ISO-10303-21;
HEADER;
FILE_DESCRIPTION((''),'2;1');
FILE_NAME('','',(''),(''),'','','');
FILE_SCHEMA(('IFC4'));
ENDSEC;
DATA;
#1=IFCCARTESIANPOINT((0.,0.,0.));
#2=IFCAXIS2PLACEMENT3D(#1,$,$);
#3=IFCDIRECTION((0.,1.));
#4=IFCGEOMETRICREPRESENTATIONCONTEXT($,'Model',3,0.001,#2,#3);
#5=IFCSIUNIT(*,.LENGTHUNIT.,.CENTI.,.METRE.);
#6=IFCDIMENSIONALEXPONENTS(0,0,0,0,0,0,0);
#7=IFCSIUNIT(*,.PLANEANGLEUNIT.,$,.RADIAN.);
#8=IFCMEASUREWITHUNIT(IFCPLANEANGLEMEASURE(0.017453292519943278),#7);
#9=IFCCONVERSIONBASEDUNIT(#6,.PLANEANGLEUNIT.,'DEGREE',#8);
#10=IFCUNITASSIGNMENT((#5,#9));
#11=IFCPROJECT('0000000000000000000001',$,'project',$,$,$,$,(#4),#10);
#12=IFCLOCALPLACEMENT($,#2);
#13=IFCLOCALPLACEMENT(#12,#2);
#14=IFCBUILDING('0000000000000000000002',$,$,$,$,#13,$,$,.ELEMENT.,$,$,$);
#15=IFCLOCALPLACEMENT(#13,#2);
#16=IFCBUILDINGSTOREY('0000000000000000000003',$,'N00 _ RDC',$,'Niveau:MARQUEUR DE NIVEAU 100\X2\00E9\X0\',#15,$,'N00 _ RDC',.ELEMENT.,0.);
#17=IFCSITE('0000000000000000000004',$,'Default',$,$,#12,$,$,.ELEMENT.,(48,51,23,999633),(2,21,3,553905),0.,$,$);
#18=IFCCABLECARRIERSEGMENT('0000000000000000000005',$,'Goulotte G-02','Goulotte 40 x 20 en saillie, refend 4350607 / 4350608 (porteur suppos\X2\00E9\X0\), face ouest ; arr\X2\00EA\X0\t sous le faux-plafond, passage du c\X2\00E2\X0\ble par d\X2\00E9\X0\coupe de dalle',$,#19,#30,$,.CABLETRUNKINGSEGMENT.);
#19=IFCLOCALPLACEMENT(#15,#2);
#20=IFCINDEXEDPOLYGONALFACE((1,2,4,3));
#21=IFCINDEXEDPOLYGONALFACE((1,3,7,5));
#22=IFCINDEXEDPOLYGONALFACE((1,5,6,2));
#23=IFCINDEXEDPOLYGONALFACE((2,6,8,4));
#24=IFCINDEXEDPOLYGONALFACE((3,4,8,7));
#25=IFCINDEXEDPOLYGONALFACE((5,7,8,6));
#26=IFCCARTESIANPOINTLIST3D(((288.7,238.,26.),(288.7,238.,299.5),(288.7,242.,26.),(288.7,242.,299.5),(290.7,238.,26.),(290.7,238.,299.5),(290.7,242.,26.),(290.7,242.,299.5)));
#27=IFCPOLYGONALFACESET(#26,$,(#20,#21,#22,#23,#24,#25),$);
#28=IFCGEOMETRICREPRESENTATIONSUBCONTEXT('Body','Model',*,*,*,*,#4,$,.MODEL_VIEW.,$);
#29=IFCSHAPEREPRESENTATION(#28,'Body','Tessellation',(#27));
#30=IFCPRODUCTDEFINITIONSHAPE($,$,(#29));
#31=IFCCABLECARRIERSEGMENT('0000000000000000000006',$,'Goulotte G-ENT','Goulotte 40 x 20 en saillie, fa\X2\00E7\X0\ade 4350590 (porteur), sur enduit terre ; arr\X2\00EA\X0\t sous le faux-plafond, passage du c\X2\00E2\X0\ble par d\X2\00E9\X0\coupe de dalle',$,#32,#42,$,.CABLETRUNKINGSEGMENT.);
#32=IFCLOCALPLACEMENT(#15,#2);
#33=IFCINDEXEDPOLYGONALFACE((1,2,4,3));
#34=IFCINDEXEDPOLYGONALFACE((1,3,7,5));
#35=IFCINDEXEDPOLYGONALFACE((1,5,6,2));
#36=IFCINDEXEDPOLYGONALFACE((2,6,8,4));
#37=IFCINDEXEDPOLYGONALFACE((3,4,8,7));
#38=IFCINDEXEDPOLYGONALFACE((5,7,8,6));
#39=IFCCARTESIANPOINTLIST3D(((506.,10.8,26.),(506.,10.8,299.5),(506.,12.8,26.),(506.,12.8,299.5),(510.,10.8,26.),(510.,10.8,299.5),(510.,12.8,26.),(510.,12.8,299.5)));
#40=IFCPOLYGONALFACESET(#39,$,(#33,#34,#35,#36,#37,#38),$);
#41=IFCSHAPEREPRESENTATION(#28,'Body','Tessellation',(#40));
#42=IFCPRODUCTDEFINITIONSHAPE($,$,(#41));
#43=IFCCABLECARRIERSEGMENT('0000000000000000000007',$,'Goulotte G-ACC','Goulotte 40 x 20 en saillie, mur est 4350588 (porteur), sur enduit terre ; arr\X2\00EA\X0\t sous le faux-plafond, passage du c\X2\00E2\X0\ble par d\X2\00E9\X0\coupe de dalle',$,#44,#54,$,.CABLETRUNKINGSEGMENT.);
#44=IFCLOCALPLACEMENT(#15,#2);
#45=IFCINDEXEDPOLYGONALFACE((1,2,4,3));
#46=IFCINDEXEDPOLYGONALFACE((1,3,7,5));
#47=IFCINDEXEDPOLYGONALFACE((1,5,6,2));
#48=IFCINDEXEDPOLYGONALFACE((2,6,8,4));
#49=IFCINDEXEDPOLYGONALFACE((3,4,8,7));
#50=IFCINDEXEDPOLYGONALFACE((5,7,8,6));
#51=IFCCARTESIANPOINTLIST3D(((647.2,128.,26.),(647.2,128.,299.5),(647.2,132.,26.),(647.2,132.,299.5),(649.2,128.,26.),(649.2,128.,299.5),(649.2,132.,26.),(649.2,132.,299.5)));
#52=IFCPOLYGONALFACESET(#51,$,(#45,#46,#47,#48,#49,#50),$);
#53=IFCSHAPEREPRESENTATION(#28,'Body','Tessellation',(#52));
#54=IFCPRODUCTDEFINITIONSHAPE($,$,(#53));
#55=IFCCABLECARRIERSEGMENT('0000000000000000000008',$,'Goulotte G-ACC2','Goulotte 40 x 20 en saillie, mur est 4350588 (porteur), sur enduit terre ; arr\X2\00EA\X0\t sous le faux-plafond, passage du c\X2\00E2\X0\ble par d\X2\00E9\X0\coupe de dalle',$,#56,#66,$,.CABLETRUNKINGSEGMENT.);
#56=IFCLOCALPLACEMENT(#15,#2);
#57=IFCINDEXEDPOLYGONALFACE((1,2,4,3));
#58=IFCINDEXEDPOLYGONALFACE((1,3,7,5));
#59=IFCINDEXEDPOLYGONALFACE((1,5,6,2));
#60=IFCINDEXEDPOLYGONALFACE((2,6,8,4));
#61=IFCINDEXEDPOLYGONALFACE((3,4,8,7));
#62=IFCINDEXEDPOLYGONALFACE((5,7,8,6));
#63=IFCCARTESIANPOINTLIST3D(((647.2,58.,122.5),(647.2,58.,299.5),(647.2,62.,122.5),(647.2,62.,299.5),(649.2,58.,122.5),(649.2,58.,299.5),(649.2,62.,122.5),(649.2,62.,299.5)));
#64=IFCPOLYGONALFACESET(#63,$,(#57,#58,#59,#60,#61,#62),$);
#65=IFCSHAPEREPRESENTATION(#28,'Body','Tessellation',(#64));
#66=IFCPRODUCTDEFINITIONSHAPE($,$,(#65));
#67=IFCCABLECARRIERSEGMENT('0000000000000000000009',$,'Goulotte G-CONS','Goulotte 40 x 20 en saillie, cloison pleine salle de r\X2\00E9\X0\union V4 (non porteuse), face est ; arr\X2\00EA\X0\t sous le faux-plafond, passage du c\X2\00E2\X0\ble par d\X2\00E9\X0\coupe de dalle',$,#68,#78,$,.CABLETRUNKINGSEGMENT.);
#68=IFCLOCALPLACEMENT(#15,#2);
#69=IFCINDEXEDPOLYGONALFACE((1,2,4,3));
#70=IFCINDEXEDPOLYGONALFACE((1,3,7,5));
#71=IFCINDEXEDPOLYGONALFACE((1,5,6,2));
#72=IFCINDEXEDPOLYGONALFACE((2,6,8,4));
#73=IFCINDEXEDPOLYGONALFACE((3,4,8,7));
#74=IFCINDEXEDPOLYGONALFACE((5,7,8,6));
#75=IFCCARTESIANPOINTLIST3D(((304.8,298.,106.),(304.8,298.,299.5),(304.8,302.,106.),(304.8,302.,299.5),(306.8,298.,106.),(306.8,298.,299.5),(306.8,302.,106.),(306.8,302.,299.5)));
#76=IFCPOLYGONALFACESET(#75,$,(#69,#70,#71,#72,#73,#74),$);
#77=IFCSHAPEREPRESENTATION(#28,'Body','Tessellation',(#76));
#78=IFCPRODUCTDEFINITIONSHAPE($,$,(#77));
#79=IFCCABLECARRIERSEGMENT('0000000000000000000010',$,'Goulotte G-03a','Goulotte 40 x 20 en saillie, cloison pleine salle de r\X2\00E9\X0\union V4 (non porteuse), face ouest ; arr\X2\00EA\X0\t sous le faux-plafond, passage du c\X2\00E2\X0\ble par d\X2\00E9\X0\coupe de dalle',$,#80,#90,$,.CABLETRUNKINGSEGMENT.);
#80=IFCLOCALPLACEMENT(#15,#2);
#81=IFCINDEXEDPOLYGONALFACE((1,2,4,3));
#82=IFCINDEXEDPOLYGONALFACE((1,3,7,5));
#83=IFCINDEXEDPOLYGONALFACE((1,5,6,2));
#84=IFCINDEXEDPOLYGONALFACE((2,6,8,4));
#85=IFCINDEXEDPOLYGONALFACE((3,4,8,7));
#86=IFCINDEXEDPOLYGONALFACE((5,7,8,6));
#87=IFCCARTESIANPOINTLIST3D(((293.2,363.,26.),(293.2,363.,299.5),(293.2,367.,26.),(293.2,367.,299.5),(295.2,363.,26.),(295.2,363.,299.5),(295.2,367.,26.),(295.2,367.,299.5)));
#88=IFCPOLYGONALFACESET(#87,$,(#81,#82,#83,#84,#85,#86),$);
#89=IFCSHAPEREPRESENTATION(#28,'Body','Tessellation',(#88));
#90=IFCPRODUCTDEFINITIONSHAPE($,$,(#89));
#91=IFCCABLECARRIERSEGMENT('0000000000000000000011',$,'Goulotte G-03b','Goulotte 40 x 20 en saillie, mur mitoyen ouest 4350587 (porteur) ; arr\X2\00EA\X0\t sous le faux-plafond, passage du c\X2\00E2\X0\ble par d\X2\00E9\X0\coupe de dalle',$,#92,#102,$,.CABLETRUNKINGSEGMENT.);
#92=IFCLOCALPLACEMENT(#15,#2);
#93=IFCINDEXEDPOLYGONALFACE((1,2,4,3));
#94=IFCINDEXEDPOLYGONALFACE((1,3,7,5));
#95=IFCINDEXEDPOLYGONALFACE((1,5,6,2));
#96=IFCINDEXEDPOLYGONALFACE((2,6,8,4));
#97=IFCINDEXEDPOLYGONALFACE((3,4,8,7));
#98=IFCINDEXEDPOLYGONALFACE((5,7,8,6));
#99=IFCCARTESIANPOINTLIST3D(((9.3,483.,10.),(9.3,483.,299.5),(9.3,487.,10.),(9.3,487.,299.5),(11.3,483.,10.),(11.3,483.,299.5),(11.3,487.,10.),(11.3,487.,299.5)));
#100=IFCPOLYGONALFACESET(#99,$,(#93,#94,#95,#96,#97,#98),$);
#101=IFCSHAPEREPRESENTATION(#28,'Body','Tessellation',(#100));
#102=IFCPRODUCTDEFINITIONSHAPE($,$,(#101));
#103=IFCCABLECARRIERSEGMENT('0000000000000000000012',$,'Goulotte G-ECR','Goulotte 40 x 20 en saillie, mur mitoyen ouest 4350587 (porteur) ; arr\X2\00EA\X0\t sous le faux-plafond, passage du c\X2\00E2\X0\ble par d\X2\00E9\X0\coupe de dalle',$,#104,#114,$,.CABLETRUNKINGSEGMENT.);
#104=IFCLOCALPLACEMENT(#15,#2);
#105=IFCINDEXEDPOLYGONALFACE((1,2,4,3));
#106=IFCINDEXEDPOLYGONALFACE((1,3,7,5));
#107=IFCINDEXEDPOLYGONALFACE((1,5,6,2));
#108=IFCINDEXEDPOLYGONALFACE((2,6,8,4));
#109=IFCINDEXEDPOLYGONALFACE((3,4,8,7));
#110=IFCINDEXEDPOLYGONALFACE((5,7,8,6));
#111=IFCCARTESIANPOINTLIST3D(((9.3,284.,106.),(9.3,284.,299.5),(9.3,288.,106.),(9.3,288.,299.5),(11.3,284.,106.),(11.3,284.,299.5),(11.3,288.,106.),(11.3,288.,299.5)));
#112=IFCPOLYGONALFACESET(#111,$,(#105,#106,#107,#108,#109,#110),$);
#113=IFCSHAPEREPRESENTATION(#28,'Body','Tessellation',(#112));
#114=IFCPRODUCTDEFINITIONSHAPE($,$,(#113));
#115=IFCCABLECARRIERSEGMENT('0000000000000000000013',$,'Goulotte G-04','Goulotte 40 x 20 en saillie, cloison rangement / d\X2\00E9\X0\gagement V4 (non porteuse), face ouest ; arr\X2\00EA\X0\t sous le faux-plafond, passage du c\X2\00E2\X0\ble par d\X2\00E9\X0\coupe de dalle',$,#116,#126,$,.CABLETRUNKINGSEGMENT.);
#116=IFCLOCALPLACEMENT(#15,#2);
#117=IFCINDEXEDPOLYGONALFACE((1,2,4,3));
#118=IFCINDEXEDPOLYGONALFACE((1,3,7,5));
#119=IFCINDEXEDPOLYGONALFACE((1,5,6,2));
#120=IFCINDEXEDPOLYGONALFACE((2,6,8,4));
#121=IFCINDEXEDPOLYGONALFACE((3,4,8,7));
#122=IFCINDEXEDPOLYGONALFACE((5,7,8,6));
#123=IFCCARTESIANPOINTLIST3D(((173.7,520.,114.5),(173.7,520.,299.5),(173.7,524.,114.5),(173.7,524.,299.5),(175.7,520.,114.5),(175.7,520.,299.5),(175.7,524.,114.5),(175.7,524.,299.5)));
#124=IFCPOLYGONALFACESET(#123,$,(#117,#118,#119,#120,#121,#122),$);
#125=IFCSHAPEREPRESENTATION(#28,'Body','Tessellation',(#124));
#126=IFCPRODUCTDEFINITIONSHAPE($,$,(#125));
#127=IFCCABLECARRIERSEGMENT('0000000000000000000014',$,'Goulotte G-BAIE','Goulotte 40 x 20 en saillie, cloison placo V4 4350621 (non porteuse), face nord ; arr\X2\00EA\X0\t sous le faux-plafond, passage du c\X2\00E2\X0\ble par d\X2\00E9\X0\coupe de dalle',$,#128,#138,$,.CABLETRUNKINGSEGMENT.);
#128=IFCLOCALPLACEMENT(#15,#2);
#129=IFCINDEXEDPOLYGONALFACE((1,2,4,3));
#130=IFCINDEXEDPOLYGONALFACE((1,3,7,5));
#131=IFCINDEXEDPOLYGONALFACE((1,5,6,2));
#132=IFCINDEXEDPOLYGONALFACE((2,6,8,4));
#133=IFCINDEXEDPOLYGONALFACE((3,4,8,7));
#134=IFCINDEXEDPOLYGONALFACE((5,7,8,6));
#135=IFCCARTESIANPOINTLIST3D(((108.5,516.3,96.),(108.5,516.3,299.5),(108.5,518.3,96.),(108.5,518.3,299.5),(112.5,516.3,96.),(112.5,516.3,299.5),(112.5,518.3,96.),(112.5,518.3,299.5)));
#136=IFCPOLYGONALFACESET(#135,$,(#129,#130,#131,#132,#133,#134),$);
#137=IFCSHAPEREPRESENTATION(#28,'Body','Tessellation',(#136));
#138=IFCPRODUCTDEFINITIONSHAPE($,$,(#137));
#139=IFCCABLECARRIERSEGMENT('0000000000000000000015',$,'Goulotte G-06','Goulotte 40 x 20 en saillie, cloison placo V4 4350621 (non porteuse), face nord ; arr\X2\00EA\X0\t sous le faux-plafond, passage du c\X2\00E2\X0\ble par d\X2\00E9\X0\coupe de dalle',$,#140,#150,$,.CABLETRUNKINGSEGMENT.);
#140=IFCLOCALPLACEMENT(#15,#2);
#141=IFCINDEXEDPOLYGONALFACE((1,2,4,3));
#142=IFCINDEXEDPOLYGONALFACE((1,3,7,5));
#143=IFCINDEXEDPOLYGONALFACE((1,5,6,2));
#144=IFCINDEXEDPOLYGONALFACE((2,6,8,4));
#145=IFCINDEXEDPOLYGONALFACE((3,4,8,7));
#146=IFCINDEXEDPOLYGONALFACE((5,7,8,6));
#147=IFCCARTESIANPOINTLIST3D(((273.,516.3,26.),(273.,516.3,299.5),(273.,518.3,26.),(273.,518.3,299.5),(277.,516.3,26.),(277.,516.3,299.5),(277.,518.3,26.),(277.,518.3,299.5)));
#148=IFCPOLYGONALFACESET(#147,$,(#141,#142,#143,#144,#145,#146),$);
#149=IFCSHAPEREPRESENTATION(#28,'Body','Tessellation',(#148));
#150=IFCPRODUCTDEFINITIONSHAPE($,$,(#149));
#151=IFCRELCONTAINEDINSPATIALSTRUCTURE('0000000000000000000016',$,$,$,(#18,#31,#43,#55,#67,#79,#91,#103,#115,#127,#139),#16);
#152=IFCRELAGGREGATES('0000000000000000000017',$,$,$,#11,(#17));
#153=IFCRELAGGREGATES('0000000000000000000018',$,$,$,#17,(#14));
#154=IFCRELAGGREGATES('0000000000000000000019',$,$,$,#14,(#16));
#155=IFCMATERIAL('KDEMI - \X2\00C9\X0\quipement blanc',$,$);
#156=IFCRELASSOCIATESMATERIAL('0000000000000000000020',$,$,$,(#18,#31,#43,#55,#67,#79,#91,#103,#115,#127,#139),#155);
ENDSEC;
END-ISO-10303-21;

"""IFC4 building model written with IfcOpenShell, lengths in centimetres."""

from ifc_helpers import new_model, entity, si_unit, converted_unit, direction, frame, frame_2d, origin, origin_with_axes, place, context, subcontext, project, spatial, rectangle, extrude, material, element, save


model = new_model("IFC4")

# Units and contexts
model_context = context("Model", 3, precision=0.001, world=origin(), true_north=direction((0.0, 1.0)))
body_context = subcontext(model_context, "Body", "Model", "MODEL_VIEW")
ifc_project = project(units=[si_unit("LENGTHUNIT", "METRE", prefix="CENTI"), converted_unit("PLANEANGLEUNIT", "DEGREE", entity("IfcPlaneAngleMeasure", 0.017453292519943278), si_unit("PLANEANGLEUNIT", "RADIAN"), dimensions=[0, 0, 0, 0, 0, 0, 0])], contexts=[model_context])

# Site, building, storey
site_placement = place(None, origin())
site = spatial("IfcSite", under=ifc_project, at=site_placement, Name="Default", CompositionType="ELEMENT", RefLatitude=(48, 51, 23, 999633), RefLongitude=(2, 21, 3, 553905), RefElevation=0.0)
building_placement = place(site_placement, origin())
building = spatial("IfcBuilding", under=site, at=building_placement, CompositionType="ELEMENT")
storey_placement = place(building_placement, origin())
storey = spatial("IfcBuildingStorey", under=building, at=storey_placement, Name="N00 _ RDC", ObjectType="Niveau:MARQUEUR DE NIVEAU 100é", LongName="N00 _ RDC", CompositionType="ELEMENT", Elevation=0.0)

# Shared definitions
ifc_material_1 = material(Name="KDEMI - Équipement blanc")

# Cable carrier segments
cable_carrier_segment_1_placement = place(storey_placement, origin_with_axes())
element("IfcCableCarrierSegment", 1, at=cable_carrier_segment_1_placement, inside=storey, material=ifc_material_1, Name="Goulotte G-02", Description="Goulotte 40 x 20 en saillie, refend 4350607 / 4350608 (porteur supposé), face ouest ; arrêt sous le faux-plafond, passage du câble par découpe de dalle", PredefinedType="CABLETRUNKINGSEGMENT", context=body_context, shape_type="SweptSolid", body=[
    extrude(rectangle(XDim=2.0, YDim=4.0, at=frame_2d((289.7, 240.0))), frame((0.0, 0.0, 26.0)), (0.0, 0.0, 1.0), 273.5),
])
cable_carrier_segment_2_placement = place(storey_placement, origin_with_axes())
element("IfcCableCarrierSegment", 2, at=cable_carrier_segment_2_placement, inside=storey, material=ifc_material_1, Name="Goulotte G-ENT", Description="Goulotte 40 x 20 en saillie, façade 4350590 (porteur), sur enduit terre ; arrêt sous le faux-plafond, passage du câble par découpe de dalle", PredefinedType="CABLETRUNKINGSEGMENT", context=body_context, shape_type="SweptSolid", body=[
    extrude(rectangle(XDim=4.0, YDim=2.0, at=frame_2d((508.0, 11.8))), frame((0.0, 0.0, 26.0)), (0.0, 0.0, 1.0), 273.5),
])
cable_carrier_segment_3_placement = place(storey_placement, origin_with_axes())
element("IfcCableCarrierSegment", 3, at=cable_carrier_segment_3_placement, inside=storey, material=ifc_material_1, Name="Goulotte G-ACC", Description="Goulotte 40 x 20 en saillie, mur est 4350588 (porteur), sur enduit terre ; arrêt sous le faux-plafond, passage du câble par découpe de dalle", PredefinedType="CABLETRUNKINGSEGMENT", context=body_context, shape_type="SweptSolid", body=[
    extrude(rectangle(XDim=2.0, YDim=4.0, at=frame_2d((648.2, 130.0))), frame((0.0, 0.0, 26.0)), (0.0, 0.0, 1.0), 273.5),
])
cable_carrier_segment_4_placement = place(storey_placement, origin_with_axes())
element("IfcCableCarrierSegment", 4, at=cable_carrier_segment_4_placement, inside=storey, material=ifc_material_1, Name="Goulotte G-ACC2", Description="Goulotte 40 x 20 en saillie, mur est 4350588 (porteur), sur enduit terre ; arrêt sous le faux-plafond, passage du câble par découpe de dalle", PredefinedType="CABLETRUNKINGSEGMENT", context=body_context, shape_type="SweptSolid", body=[
    extrude(rectangle(XDim=2.0, YDim=4.0, at=frame_2d((648.2, 60.0))), frame((0.0, 0.0, 122.5)), (0.0, 0.0, 1.0), 177.0),
])
cable_carrier_segment_5_placement = place(storey_placement, origin_with_axes())
element("IfcCableCarrierSegment", 5, at=cable_carrier_segment_5_placement, inside=storey, material=ifc_material_1, Name="Goulotte G-CONS", Description="Goulotte 40 x 20 en saillie, cloison pleine salle de réunion V4 (non porteuse), face est ; arrêt sous le faux-plafond, passage du câble par découpe de dalle", PredefinedType="CABLETRUNKINGSEGMENT", context=body_context, shape_type="SweptSolid", body=[
    extrude(rectangle(XDim=2.0, YDim=4.0, at=frame_2d((305.8, 300.0))), frame((0.0, 0.0, 106.0)), (0.0, 0.0, 1.0), 193.5),
])
cable_carrier_segment_6_placement = place(storey_placement, origin_with_axes())
element("IfcCableCarrierSegment", 6, at=cable_carrier_segment_6_placement, inside=storey, material=ifc_material_1, Name="Goulotte G-03a", Description="Goulotte 40 x 20 en saillie, cloison pleine salle de réunion V4 (non porteuse), face ouest ; arrêt sous le faux-plafond, passage du câble par découpe de dalle", PredefinedType="CABLETRUNKINGSEGMENT", context=body_context, shape_type="SweptSolid", body=[
    extrude(rectangle(XDim=2.0, YDim=4.0, at=frame_2d((294.2, 365.0))), frame((0.0, 0.0, 26.0)), (0.0, 0.0, 1.0), 273.5),
])
cable_carrier_segment_7_placement = place(storey_placement, origin_with_axes())
element("IfcCableCarrierSegment", 7, at=cable_carrier_segment_7_placement, inside=storey, material=ifc_material_1, Name="Goulotte G-03b", Description="Goulotte 40 x 20 en saillie, mur mitoyen ouest 4350587 (porteur) ; arrêt sous le faux-plafond, passage du câble par découpe de dalle", PredefinedType="CABLETRUNKINGSEGMENT", context=body_context, shape_type="SweptSolid", body=[
    extrude(rectangle(XDim=2.0, YDim=4.0, at=frame_2d((10.3, 485.0))), frame((0.0, 0.0, 10.0)), (0.0, 0.0, 1.0), 289.5),
])
cable_carrier_segment_8_placement = place(storey_placement, origin_with_axes())
element("IfcCableCarrierSegment", 8, at=cable_carrier_segment_8_placement, inside=storey, material=ifc_material_1, Name="Goulotte G-ECR", Description="Goulotte 40 x 20 en saillie, mur mitoyen ouest 4350587 (porteur) ; arrêt sous le faux-plafond, passage du câble par découpe de dalle", PredefinedType="CABLETRUNKINGSEGMENT", context=body_context, shape_type="SweptSolid", body=[
    extrude(rectangle(XDim=2.0, YDim=4.0, at=frame_2d((10.3, 286.0))), frame((0.0, 0.0, 106.0)), (0.0, 0.0, 1.0), 193.5),
])
cable_carrier_segment_9_placement = place(storey_placement, origin_with_axes())
element("IfcCableCarrierSegment", 9, at=cable_carrier_segment_9_placement, inside=storey, material=ifc_material_1, Name="Goulotte G-04", Description="Goulotte 40 x 20 en saillie, cloison rangement / dégagement V4 (non porteuse), face ouest ; arrêt sous le faux-plafond, passage du câble par découpe de dalle", PredefinedType="CABLETRUNKINGSEGMENT", context=body_context, shape_type="SweptSolid", body=[
    extrude(rectangle(XDim=2.0, YDim=4.0, at=frame_2d((174.7, 522.0))), frame((0.0, 0.0, 114.5)), (0.0, 0.0, 1.0), 185.0),
])
cable_carrier_segment_10_placement = place(storey_placement, origin_with_axes())
element("IfcCableCarrierSegment", 10, at=cable_carrier_segment_10_placement, inside=storey, material=ifc_material_1, Name="Goulotte G-BAIE", Description="Goulotte 40 x 20 en saillie, cloison placo V4 4350621 (non porteuse), face nord ; arrêt sous le faux-plafond, passage du câble par découpe de dalle", PredefinedType="CABLETRUNKINGSEGMENT", context=body_context, shape_type="SweptSolid", body=[
    extrude(rectangle(XDim=4.0, YDim=2.0, at=frame_2d((110.5, 517.3))), frame((0.0, 0.0, 96.0)), (0.0, 0.0, 1.0), 203.5),
])
cable_carrier_segment_11_placement = place(storey_placement, origin_with_axes())
element("IfcCableCarrierSegment", 11, at=cable_carrier_segment_11_placement, inside=storey, material=ifc_material_1, Name="Goulotte G-06", Description="Goulotte 40 x 20 en saillie, cloison placo V4 4350621 (non porteuse), face nord ; arrêt sous le faux-plafond, passage du câble par découpe de dalle", PredefinedType="CABLETRUNKINGSEGMENT", context=body_context, shape_type="SweptSolid", body=[
    extrude(rectangle(XDim=4.0, YDim=2.0, at=frame_2d((275.0, 517.3))), frame((0.0, 0.0, 26.0)), (0.0, 0.0, 1.0), 273.5),
])

save(model, "model.ifc")
